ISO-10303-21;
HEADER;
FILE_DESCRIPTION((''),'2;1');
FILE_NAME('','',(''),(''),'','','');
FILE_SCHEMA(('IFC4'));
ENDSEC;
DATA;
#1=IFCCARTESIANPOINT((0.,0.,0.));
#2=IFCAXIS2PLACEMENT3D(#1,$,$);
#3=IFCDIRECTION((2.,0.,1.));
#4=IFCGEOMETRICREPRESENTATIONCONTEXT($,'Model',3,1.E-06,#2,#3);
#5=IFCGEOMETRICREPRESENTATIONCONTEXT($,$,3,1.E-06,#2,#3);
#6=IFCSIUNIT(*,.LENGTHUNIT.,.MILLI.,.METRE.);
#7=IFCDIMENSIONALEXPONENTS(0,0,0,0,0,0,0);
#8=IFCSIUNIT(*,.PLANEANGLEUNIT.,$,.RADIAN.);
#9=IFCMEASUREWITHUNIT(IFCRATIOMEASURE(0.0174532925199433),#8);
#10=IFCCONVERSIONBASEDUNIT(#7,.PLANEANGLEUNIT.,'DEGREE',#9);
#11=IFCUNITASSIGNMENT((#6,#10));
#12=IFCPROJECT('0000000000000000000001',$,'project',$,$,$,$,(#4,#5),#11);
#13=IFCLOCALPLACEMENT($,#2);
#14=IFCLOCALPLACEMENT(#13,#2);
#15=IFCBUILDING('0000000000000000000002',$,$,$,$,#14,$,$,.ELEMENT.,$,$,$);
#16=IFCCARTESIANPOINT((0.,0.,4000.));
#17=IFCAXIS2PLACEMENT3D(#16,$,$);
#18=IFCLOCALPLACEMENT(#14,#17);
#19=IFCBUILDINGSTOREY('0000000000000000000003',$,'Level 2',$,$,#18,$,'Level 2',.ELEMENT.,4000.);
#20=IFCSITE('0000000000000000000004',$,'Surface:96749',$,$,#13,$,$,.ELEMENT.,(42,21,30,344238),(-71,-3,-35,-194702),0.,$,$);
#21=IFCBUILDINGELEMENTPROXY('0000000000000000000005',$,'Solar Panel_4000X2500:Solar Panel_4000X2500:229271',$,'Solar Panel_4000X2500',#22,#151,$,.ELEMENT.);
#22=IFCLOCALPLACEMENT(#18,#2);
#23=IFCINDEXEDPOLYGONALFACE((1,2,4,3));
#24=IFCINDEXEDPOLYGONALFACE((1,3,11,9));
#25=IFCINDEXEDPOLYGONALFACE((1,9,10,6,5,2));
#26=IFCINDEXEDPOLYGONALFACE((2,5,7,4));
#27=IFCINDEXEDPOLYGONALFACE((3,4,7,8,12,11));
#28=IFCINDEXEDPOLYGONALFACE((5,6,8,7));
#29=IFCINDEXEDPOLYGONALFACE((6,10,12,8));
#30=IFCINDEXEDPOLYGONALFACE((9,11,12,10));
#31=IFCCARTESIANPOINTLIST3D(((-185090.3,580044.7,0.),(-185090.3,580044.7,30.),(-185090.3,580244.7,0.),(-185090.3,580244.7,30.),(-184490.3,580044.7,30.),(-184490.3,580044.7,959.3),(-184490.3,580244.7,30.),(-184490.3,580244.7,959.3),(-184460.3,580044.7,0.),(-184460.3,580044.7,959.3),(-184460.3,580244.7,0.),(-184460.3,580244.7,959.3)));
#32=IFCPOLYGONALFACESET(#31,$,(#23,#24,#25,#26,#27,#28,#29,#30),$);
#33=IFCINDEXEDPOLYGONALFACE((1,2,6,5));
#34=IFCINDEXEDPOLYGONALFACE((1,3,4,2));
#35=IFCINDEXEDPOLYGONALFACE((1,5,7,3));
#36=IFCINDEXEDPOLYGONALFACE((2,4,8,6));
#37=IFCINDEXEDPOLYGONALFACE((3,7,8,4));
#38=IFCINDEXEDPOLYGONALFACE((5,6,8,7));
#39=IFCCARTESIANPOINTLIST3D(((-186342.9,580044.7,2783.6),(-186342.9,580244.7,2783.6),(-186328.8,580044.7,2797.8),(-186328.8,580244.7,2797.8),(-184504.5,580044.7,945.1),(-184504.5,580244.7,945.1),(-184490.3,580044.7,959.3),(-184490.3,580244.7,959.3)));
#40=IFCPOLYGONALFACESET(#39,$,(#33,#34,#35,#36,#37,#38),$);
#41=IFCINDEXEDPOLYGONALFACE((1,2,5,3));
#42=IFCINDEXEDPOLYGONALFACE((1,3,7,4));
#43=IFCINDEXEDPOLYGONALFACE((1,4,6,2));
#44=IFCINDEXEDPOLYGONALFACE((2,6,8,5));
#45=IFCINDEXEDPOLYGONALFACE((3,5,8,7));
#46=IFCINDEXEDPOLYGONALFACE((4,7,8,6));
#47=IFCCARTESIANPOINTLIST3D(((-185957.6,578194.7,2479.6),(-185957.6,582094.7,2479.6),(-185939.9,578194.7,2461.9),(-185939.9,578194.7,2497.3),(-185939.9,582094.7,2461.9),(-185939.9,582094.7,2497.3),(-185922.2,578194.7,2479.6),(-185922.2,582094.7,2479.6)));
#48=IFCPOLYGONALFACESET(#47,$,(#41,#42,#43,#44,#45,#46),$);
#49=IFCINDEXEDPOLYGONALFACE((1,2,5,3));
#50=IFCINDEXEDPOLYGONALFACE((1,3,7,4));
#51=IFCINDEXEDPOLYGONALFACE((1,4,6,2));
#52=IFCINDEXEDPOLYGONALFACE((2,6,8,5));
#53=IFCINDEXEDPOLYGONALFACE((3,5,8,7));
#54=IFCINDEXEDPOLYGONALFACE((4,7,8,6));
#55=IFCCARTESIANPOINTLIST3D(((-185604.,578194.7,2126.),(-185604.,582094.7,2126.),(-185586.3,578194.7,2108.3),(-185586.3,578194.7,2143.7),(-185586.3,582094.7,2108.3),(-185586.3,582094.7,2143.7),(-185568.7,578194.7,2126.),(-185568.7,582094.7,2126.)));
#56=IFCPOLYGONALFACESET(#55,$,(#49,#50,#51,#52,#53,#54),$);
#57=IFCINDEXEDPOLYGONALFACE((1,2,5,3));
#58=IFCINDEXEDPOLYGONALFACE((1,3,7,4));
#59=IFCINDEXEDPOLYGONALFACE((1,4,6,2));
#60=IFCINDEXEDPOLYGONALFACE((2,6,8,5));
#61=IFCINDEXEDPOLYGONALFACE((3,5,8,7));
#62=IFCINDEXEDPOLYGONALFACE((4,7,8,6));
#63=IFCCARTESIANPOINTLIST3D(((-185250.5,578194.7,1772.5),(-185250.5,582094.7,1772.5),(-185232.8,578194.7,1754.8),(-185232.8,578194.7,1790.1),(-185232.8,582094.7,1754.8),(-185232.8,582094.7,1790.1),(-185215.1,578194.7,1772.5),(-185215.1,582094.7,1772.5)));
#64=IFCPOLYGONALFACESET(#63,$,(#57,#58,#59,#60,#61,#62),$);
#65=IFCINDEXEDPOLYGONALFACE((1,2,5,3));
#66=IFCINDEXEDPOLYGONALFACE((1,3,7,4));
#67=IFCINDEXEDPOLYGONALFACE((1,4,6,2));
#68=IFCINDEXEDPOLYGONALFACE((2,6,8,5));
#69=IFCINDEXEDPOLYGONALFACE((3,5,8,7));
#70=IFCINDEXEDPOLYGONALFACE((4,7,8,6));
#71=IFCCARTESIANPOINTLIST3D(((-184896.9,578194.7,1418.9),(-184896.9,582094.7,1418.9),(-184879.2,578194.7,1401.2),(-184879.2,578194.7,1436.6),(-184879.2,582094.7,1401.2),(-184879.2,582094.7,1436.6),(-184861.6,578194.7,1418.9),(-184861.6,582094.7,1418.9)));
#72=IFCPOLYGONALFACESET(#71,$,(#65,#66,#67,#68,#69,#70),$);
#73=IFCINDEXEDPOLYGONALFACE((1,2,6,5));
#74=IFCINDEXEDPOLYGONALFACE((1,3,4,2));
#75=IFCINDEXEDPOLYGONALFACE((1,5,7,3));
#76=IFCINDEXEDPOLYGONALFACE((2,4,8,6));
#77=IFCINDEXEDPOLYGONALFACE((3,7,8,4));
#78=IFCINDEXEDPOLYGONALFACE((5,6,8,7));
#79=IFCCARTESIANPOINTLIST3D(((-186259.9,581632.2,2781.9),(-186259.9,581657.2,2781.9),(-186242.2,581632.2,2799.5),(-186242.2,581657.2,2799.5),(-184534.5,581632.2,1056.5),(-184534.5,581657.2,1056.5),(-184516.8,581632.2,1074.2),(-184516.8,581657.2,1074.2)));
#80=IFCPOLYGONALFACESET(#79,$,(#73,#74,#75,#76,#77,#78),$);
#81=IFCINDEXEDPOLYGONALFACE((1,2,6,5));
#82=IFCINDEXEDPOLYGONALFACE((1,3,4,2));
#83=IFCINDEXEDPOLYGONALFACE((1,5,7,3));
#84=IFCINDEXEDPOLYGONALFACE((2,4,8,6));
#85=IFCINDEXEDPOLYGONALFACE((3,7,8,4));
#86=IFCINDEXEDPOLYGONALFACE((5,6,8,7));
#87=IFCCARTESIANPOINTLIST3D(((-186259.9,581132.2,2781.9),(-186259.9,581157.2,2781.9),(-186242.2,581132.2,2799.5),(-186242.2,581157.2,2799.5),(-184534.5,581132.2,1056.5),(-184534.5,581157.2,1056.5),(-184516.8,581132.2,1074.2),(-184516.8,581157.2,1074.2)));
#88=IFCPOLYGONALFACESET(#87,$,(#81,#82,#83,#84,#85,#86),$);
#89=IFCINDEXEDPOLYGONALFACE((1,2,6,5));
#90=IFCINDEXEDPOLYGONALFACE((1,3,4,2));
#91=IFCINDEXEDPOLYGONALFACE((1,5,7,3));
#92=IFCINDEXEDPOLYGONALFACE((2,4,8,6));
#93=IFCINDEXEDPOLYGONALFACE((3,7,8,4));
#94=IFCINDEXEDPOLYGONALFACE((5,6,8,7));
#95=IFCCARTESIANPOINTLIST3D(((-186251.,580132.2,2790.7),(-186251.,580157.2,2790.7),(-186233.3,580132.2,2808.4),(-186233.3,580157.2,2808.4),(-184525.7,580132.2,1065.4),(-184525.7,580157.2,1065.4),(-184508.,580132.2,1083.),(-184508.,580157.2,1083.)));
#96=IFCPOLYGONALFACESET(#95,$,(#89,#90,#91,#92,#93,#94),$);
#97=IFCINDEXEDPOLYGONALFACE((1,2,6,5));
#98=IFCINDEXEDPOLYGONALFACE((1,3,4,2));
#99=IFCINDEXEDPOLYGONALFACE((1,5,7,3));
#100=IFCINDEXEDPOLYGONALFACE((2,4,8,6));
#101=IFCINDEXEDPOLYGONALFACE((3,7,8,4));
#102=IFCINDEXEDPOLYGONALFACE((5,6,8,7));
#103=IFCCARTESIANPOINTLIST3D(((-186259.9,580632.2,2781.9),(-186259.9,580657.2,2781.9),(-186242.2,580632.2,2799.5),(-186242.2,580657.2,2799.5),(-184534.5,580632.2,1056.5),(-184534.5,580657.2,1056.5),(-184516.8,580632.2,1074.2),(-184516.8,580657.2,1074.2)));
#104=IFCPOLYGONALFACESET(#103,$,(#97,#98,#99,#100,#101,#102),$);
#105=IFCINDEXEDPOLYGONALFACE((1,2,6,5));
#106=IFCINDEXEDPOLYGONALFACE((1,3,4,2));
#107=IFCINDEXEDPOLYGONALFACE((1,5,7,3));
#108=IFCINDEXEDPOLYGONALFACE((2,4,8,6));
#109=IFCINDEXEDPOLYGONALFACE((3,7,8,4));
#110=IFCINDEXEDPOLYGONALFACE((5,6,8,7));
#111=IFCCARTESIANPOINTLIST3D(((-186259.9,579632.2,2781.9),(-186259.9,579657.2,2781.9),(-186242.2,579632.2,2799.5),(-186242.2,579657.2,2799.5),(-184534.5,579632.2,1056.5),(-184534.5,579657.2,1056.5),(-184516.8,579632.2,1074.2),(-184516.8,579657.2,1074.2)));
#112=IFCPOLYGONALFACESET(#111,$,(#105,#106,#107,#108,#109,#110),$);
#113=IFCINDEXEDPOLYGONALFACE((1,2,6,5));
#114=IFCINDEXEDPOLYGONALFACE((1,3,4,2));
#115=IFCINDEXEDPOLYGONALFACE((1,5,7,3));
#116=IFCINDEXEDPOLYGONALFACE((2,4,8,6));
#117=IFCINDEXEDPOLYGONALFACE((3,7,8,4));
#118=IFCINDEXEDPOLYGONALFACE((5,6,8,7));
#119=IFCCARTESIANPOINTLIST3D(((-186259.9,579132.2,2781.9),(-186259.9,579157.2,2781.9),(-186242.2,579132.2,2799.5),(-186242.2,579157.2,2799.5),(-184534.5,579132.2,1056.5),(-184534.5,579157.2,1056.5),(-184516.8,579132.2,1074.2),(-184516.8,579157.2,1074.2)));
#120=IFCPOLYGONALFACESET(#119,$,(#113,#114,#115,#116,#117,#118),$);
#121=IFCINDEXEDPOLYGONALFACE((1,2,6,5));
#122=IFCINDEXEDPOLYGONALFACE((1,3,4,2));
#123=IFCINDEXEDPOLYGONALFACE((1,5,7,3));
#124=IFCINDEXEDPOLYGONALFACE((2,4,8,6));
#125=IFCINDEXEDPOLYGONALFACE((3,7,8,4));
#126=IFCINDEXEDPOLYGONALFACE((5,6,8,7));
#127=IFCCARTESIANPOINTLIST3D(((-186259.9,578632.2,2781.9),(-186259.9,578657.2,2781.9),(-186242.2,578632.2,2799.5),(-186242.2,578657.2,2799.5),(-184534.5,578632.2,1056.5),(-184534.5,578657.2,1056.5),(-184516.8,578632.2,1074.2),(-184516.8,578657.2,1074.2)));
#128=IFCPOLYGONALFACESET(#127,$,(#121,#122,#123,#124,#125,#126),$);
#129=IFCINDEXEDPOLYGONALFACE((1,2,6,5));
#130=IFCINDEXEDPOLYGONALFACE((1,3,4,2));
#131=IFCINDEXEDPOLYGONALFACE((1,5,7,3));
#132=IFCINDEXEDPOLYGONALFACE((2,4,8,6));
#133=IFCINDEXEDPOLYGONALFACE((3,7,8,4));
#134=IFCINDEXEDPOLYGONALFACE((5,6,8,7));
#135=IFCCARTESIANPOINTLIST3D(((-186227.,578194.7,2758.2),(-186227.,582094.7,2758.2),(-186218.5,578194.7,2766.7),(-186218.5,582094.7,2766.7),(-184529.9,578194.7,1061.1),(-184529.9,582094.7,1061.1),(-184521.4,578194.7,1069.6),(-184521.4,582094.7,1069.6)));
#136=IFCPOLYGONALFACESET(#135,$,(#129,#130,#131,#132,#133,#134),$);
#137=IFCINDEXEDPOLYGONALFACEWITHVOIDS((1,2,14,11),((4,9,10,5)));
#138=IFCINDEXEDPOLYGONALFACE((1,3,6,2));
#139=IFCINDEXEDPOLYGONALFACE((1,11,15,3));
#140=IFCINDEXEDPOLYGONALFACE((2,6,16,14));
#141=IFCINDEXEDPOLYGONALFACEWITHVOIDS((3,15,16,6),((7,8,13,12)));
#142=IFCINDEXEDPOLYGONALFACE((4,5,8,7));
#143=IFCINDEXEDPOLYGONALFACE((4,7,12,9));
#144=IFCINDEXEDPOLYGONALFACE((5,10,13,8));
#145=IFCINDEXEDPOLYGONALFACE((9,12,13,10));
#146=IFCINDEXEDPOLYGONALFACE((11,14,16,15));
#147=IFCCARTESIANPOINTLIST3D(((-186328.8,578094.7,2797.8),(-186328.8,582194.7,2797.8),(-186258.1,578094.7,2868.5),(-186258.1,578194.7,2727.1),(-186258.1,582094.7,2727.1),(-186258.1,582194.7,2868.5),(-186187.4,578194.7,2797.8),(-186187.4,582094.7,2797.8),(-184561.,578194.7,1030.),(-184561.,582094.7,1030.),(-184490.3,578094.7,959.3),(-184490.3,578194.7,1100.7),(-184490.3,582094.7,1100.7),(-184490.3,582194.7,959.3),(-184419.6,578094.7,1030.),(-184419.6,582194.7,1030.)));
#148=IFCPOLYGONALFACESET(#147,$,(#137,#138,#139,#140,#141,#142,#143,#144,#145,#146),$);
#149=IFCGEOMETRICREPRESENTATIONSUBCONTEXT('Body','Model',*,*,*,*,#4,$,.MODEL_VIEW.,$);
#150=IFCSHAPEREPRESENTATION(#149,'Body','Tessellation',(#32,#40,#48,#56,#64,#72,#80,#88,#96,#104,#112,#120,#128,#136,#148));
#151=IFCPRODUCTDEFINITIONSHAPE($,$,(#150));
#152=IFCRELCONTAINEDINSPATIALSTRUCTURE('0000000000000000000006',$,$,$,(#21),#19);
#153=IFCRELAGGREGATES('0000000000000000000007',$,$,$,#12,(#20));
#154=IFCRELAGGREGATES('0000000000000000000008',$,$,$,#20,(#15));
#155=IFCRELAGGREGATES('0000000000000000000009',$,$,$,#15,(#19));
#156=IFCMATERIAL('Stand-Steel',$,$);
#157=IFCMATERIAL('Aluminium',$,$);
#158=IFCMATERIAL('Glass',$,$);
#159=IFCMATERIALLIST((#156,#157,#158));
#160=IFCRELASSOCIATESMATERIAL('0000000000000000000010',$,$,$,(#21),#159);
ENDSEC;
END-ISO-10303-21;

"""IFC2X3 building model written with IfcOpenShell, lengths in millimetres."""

from ifc_helpers import new_model, entity, si_unit, converted_unit, direction, frame, frame_2d, origin, origin_2d_with_axis, place, context, subcontext, project, spatial, polyline, rectangle, outline, extrude, source, transform, mapped, material, material_list, element, save


model = new_model("IFC2X3")

# Units and contexts
model_context = context("Model", 3, precision=1e-06, world=origin(), true_north=direction((2.0, 0.0, 1.0)))
context_of_model = context(None, 3, precision=1e-06, world=origin(), true_north=direction((2.0, 0.0, 1.0)))
body_context = subcontext(model_context, "Body", "Model", "MODEL_VIEW")
ifc_project = project(units=[si_unit("LENGTHUNIT", "METRE", prefix="MILLI"), converted_unit("PLANEANGLEUNIT", "DEGREE", entity("IfcRatioMeasure", 0.0174532925199433), si_unit("PLANEANGLEUNIT", "RADIAN"), dimensions=[0, 0, 0, 0, 0, 0, 0])], contexts=[model_context, context_of_model])

# Site, building, storey
site_placement = place(None, origin())
site = spatial("IfcSite", under=ifc_project, at=site_placement, Name="Surface:96749", CompositionType="ELEMENT", RefLatitude=(42, 21, 30, 344238), RefLongitude=(-71, -3, -35, -194702), RefElevation=0.0)
building_placement = place(site_placement, origin())
building = spatial("IfcBuilding", under=site, at=building_placement, CompositionType="ELEMENT")
storey_placement = place(building_placement, frame((0.0, 0.0, 4000.0)))
storey = spatial("IfcBuildingStorey", under=building, at=storey_placement, Name="Level 2", LongName="Level 2", CompositionType="ELEMENT", Elevation=4000.0)

# Building element proxy
ifc_material_1 = material(Name="Stand-Steel")
ifc_material_2 = material(Name="Aluminium")
ifc_material_3 = material(Name="Glass")
shared_shape = source(origin(), body_context, "Body", "SweptSolid", [
    extrude(outline(polyline([(-629.5, -220.0), (329.8, -220.0), (329.8, 410.0), (299.8, 410.0), (299.8, -190.0), (-629.5, -190.0), (-629.5, -220.0)])), frame((-190.0, -100.0, 299.8), z_axis=(0.0, 1.0, 0.0), x_axis=(0.0, 0.0, -1.0)), (0.0, 0.0, 1.0), 200.0),
    extrude(rectangle(XDim=20.0, YDim=200.0, at=frame_2d((0.0, 0.0), x_axis=(0.0, 1.0))), frame((-7.1, 0.0, 922.2), z_axis=(-0.707107, 0.0, 0.707107), x_axis=(0.0, 1.0, 0.0)), (0.0, 0.0, 1.0), 2600.0),
    extrude(rectangle(XDim=25.0, YDim=25.0, at=frame_2d((0.0, 0.0), x_axis=(1.0, 0.0))), frame((-1449.6, -1950.0, 2449.6), z_axis=(0.0, 1.0, 0.0), x_axis=(-0.707107, 0.0, -0.707107)), (0.0, 0.0, 1.0), 3900.0),
    extrude(rectangle(XDim=25.0, YDim=25.0, at=origin_2d_with_axis()), frame((-1096.0, -1950.0, 2096.0), z_axis=(0.0, 1.0, 0.0), x_axis=(-0.707107, 0.0, -0.707107)), (0.0, 0.0, 1.0), 3900.0),
    extrude(rectangle(XDim=25.0, YDim=25.0, at=origin_2d_with_axis()), frame((-742.5, -1950.0, 1742.5), z_axis=(0.0, 1.0, 0.0), x_axis=(-0.707107, 0.0, -0.707107)), (0.0, 0.0, 1.0), 3900.0),
    extrude(rectangle(XDim=25.0, YDim=25.0, at=frame_2d((0.0, 0.0), x_axis=(1.0, 0.0))), frame((-388.9, -1950.0, 1388.9), z_axis=(0.0, 1.0, 0.0), x_axis=(-0.707107, 0.0, -0.707107)), (0.0, 0.0, 1.0), 3900.0),
    extrude(rectangle(XDim=25.0, YDim=25.0, at=frame_2d((0.0, 0.0), x_axis=(0.0, 1.0))), frame((-35.4, 1500.0, 1035.4), z_axis=(-0.707107, 0.0, 0.707107), x_axis=(0.0, 1.0, 0.0)), (0.0, 0.0, 1.0), 2440.0),
    extrude(rectangle(XDim=25.0, YDim=25.0, at=frame_2d((0.0, 0.0), x_axis=(0.0, 1.0))), frame((-35.4, 1000.0, 1035.4), z_axis=(-0.707107, 0.0, 0.707107), x_axis=(0.0, 1.0, 0.0)), (0.0, 0.0, 1.0), 2440.0),
    extrude(rectangle(XDim=25.0, YDim=25.0, at=frame_2d((0.0, 0.0), x_axis=(0.0, 1.0))), frame((-26.5, 0.0, 1044.2), z_axis=(-0.707107, 0.0, 0.707107), x_axis=(0.0, -1.0, 0.0)), (0.0, 0.0, 1.0), 2440.0),
    extrude(rectangle(XDim=25.0, YDim=25.0, at=frame_2d((0.0, 0.0), x_axis=(0.0, 1.0))), frame((-35.4, 500.0, 1035.4), z_axis=(-0.707107, 0.0, 0.707107), x_axis=(0.0, 1.0, 0.0)), (0.0, 0.0, 1.0), 2440.0),
    extrude(rectangle(XDim=25.0, YDim=25.0, at=frame_2d((0.0, 0.0), x_axis=(0.0, 1.0))), frame((-35.4, -500.0, 1035.4), z_axis=(-0.707107, 0.0, 0.707107), x_axis=(0.0, 1.0, 0.0)), (0.0, 0.0, 1.0), 2440.0),
    extrude(rectangle(XDim=25.0, YDim=25.0, at=frame_2d((0.0, 0.0), x_axis=(0.0, 1.0))), frame((-35.4, -1000.0, 1035.4), z_axis=(-0.707107, 0.0, 0.707107), x_axis=(0.0, 1.0, 0.0)), (0.0, 0.0, 1.0), 2440.0),
    extrude(rectangle(XDim=25.0, YDim=25.0, at=frame_2d((0.0, 0.0), x_axis=(0.0, 1.0))), frame((-35.4, -1500.0, 1035.4), z_axis=(-0.707107, 0.0, 0.707107), x_axis=(0.0, 1.0, 0.0)), (0.0, 0.0, 1.0), 2440.0),
    extrude(rectangle(XDim=2400.0, YDim=12.0, at=frame_2d((0.0, 0.0), x_axis=(1.0, 0.0))), frame((-883.9, -1950.0, 1883.9), z_axis=(0.0, 1.0, 0.0), x_axis=(0.707107, 0.0, -0.707107)), (0.0, 0.0, 1.0), 3900.0),
    extrude(outline(polyline([(-2050.0, -1300.0), (2050.0, -1300.0), (2050.0, 1300.0), (-2050.0, 1300.0), (-2050.0, -1300.0)]), holes=[polyline([(1950.0, -1200.0), (-1950.0, -1200.0), (-1950.0, 1200.0), (1950.0, 1200.0), (1950.0, -1200.0)])]), frame((-919.2, 0.0, 1848.5), z_axis=(0.707107, 0.0, 0.707107), x_axis=(0.0, 1.0, 0.0)), (0.0, 0.0, 1.0), 100.0),
])
ifc_material_list_1 = material_list([ifc_material_1, ifc_material_2, ifc_material_3])
proxy_1_placement = place(storey_placement, frame((-184490.3, 580144.7, 30.0)))
element("IfcBuildingElementProxy", 1, at=proxy_1_placement, inside=storey, material=ifc_material_list_1, Name="Solar Panel_4000X2500:Solar Panel_4000X2500:229271", ObjectType="Solar Panel_4000X2500", CompositionType="ELEMENT", context=body_context, shape_type="MappedRepresentation", body=[
    mapped(shared_shape, transform((0.0, 0.0, 0.0), scale=1.0)),
])

save(model, "model.ifc")
